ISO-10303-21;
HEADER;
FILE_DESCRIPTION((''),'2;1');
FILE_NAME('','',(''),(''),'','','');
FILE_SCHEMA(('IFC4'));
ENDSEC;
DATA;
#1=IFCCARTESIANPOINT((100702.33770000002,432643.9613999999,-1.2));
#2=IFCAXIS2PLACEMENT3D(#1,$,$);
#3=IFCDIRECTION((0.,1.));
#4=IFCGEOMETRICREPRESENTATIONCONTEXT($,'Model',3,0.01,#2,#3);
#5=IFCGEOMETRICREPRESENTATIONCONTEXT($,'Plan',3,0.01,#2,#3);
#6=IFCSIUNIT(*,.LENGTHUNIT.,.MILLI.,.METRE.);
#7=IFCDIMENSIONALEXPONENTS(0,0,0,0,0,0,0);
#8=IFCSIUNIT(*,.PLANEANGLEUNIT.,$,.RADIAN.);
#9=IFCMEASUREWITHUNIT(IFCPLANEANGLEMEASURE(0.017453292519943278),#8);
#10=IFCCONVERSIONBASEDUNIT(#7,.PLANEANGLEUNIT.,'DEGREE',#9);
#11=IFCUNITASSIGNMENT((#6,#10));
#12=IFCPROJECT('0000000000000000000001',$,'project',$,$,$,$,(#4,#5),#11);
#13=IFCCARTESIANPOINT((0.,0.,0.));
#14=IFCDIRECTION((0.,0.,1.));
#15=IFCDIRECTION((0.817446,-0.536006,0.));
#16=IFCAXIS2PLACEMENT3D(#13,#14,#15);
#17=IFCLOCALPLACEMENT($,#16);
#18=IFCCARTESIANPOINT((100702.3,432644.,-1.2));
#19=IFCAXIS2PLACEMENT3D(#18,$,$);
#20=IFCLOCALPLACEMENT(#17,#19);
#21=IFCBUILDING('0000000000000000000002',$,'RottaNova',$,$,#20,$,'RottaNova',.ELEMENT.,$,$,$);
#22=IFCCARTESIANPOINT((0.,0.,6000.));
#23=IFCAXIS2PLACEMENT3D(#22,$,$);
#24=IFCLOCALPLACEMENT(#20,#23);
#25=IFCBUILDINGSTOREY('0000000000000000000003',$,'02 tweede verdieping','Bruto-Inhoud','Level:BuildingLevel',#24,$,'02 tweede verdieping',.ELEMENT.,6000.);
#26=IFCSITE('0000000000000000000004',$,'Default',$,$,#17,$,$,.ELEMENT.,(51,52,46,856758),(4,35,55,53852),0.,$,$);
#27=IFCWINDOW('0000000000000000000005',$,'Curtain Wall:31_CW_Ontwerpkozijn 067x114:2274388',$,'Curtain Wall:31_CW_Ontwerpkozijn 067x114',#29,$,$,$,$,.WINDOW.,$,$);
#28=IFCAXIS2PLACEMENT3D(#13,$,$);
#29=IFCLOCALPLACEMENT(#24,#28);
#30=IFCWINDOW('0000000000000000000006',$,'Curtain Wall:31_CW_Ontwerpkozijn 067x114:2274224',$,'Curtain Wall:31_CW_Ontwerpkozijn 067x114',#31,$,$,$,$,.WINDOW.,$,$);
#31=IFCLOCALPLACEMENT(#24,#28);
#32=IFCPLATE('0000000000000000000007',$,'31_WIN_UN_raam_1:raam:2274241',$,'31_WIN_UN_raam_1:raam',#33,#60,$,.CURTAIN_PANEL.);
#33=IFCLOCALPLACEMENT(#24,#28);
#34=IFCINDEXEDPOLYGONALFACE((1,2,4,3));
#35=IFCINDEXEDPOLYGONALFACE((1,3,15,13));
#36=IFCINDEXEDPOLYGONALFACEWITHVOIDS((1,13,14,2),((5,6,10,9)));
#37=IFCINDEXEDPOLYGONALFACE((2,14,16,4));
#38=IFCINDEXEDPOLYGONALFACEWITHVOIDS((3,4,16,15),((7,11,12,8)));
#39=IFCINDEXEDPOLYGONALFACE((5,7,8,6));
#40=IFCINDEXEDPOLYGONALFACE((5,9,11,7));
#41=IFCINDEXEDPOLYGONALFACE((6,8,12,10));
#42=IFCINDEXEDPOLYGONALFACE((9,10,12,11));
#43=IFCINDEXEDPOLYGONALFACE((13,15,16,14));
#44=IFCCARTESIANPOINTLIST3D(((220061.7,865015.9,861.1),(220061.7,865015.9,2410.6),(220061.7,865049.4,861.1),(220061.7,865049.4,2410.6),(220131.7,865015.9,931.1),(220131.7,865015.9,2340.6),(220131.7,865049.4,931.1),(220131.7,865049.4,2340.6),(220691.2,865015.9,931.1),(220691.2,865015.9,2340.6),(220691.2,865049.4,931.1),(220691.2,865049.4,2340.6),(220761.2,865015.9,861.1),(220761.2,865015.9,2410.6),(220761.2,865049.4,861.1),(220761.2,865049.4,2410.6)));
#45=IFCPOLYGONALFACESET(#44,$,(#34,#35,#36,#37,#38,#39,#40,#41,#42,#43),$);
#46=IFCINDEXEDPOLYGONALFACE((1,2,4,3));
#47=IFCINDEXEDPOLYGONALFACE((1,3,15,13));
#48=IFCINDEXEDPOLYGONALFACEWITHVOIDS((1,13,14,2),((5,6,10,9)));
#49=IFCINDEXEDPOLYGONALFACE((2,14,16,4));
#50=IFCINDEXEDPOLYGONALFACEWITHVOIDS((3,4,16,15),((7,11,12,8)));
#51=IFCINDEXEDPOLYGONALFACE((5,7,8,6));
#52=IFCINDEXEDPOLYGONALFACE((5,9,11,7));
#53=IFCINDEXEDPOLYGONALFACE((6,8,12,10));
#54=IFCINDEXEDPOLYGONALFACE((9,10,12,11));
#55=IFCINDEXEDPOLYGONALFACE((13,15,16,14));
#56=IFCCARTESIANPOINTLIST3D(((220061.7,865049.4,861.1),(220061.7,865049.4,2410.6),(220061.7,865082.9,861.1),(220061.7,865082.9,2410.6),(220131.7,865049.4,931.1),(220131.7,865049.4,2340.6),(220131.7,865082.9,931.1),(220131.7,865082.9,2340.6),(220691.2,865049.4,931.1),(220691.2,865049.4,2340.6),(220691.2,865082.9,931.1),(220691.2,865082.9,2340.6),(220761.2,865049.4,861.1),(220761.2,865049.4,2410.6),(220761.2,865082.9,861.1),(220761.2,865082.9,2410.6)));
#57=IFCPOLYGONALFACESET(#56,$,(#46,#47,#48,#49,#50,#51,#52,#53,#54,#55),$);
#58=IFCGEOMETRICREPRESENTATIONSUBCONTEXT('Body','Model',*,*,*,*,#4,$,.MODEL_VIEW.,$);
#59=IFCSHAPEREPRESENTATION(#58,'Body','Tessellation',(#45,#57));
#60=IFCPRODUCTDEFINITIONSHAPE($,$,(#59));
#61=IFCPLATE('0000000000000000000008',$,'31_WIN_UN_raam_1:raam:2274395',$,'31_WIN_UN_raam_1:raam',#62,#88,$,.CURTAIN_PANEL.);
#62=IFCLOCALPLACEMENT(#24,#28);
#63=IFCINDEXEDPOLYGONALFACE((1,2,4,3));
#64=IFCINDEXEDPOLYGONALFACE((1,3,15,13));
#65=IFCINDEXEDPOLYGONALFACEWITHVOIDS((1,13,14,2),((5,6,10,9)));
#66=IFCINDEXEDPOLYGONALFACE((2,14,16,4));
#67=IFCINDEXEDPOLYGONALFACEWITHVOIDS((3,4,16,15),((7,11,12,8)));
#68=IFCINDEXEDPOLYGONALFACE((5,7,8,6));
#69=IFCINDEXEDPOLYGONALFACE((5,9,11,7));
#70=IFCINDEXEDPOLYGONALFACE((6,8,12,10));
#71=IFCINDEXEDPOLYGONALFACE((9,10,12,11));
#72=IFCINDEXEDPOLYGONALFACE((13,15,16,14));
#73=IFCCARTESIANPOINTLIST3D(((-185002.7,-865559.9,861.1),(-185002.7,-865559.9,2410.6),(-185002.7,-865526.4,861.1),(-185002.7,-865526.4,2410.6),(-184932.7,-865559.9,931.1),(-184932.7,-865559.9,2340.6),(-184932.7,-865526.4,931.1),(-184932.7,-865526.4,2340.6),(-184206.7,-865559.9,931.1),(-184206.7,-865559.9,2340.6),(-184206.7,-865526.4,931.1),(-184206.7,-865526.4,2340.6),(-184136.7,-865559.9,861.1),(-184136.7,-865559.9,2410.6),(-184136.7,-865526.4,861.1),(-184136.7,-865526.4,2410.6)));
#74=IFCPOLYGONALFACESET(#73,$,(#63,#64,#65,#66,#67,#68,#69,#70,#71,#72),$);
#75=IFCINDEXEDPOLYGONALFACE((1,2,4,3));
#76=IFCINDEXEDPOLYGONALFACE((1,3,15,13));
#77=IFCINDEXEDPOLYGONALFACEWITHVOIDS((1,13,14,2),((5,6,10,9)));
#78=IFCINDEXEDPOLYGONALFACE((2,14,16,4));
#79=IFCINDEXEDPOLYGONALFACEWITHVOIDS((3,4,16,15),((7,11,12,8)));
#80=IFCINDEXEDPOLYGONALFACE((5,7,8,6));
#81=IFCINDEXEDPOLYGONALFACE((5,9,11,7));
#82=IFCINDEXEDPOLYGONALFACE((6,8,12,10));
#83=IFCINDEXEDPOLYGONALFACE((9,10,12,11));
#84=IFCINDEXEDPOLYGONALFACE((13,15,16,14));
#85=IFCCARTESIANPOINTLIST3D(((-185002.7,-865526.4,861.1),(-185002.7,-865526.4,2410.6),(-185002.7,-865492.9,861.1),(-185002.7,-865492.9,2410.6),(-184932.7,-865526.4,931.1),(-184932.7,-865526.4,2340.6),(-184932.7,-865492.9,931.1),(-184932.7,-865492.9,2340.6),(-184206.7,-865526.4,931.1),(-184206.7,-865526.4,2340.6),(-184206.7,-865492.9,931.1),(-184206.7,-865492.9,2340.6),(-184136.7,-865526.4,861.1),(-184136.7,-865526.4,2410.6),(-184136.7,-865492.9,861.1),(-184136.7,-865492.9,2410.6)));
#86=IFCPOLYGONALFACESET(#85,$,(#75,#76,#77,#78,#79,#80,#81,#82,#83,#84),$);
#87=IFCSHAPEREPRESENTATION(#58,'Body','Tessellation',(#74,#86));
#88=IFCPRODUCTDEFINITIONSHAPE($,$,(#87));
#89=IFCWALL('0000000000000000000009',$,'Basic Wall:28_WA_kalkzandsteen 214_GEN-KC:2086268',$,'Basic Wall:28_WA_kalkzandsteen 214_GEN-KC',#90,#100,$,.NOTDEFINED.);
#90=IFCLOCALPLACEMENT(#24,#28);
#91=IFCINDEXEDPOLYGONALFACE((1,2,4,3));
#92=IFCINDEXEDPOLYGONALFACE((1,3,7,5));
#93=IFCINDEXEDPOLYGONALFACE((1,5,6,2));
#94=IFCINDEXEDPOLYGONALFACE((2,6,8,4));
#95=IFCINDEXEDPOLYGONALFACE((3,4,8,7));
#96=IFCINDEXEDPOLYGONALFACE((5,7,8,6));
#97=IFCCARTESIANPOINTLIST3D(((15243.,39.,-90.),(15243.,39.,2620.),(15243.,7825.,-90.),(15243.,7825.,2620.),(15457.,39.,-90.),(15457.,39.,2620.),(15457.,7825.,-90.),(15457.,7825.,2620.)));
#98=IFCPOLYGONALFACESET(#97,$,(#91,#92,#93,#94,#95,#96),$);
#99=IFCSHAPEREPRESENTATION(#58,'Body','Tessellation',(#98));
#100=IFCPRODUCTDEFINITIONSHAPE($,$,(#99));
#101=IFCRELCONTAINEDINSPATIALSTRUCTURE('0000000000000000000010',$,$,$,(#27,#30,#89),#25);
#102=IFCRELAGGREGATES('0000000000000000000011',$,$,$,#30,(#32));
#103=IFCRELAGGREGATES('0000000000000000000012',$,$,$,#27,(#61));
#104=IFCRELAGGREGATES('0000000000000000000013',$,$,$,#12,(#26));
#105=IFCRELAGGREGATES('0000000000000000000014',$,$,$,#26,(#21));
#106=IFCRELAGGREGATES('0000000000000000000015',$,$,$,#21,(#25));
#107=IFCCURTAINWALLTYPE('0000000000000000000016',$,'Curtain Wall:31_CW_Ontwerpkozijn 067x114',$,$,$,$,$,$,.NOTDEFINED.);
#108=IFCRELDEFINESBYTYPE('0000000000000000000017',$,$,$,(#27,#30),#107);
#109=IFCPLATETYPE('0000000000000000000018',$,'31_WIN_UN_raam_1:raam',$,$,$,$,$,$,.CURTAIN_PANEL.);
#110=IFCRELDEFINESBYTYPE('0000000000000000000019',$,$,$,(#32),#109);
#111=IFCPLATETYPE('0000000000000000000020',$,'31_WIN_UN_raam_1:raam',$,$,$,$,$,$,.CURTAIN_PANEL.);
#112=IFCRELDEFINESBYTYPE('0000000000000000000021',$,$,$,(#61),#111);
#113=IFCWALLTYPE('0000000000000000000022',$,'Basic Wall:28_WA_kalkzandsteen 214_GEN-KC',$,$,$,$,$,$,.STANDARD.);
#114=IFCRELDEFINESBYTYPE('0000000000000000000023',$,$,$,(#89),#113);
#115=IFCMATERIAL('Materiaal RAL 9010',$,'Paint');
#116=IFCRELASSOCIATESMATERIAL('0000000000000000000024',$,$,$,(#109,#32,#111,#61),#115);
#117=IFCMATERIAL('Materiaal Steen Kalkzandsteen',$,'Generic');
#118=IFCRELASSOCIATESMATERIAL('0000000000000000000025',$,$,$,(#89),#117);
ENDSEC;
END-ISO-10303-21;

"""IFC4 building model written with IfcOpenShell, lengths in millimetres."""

from ifc_helpers import new_model, entity, si_unit, converted_unit, direction, frame, place, context, subcontext, project, spatial, indexed_curve, outline, extrude, source, transform, mapped, material, type_object, type_shapes, element, aggregate, save


model = new_model("IFC4")

# Units and contexts
model_context = context("Model", 3, precision=0.01, world=frame((100702.33770000002, 432643.9613999999, -1.2)), true_north=direction((0.0, 1.0)))
plan_context = context("Plan", 3, precision=0.01, world=frame((100702.33770000002, 432643.9613999999, -1.2)), true_north=direction((0.0, 1.0)))
body_context = subcontext(model_context, "Body", "Model", "MODEL_VIEW")
ifc_project = project(units=[si_unit("LENGTHUNIT", "METRE", prefix="MILLI"), converted_unit("PLANEANGLEUNIT", "DEGREE", entity("IfcPlaneAngleMeasure", 0.017453292519943278), si_unit("PLANEANGLEUNIT", "RADIAN"), dimensions=[0, 0, 0, 0, 0, 0, 0])], contexts=[model_context, plan_context])

# Site, building, storey
site_placement = place(None, frame((0.0, 0.0, 0.0), z_axis=(0.0, 0.0, 1.0), x_axis=(0.817446, -0.536006, 0.0)))
site = spatial("IfcSite", under=ifc_project, at=site_placement, Name="Default", CompositionType="ELEMENT", RefLatitude=(51, 52, 46, 856758), RefLongitude=(4, 35, 55, 53852), RefElevation=0.0)
building_placement = place(site_placement, frame((100702.3, 432644.0, -1.2)))
building = spatial("IfcBuilding", under=site, at=building_placement, Name="RottaNova", LongName="RottaNova", CompositionType="ELEMENT")
storey_placement = place(building_placement, frame((0.0, 0.0, 6000.0)))
storey = spatial("IfcBuildingStorey", under=building, at=storey_placement, Name="02 tweede verdieping", Description="Bruto-Inhoud", ObjectType="Level:BuildingLevel", LongName="02 tweede verdieping", CompositionType="ELEMENT", Elevation=6000.0)

# Window
curtain_wall_type = type_object("IfcCurtainWallType", Name="Curtain Wall:31_CW_Ontwerpkozijn 067x114", PredefinedType="NOTDEFINED")
window_1_placement = place(storey_placement, frame((0.0, 0.0, -6000.0)))
window_1 = element("IfcWindow", 1, at=window_1_placement, inside=storey, type_object=curtain_wall_type, Name="Curtain Wall:31_CW_Ontwerpkozijn 067x114:2274388", ObjectType="Curtain Wall:31_CW_Ontwerpkozijn 067x114", PredefinedType="WINDOW")

# Window
window_2_placement = place(storey_placement, frame((0.0, 0.0, -6000.0)))
window_2 = element("IfcWindow", 2, at=window_2_placement, inside=storey, type_object=curtain_wall_type, Name="Curtain Wall:31_CW_Ontwerpkozijn 067x114:2274224", ObjectType="Curtain Wall:31_CW_Ontwerpkozijn 067x114", PredefinedType="WINDOW")

# Plates
ifc_material_1 = material(Name="Materiaal RAL 9010", Category="Paint")
plate_type_1 = type_object("IfcPlateType", Name="31_WIN_UN_raam_1:raam", PredefinedType="CURTAIN_PANEL", material=ifc_material_1)
shared_shape_1 = source(frame((100702.3, 432644.0, -1.2)), body_context, "Body", "SweptSolid", [
    extrude(outline(indexed_curve([(-349.7, -774.8), (349.7, -774.8), (349.7, 774.8), (-349.7, 774.8), (-349.7, -774.8)], self_intersect=False), holes=[indexed_curve([(-279.7, 704.8), (279.7, 704.8), (279.7, -704.8), (-279.7, -704.8), (-279.7, 704.8)], self_intersect=False)]), frame((0.0, -92.0, 774.8), z_axis=(0.0, 1.0, 0.0), x_axis=(1.0, 0.0, 0.0)), (0.0, 0.0, 1.0), 33.5),
    extrude(outline(indexed_curve([(-349.7, -774.8), (349.7, -774.8), (349.7, 774.8), (-349.7, 774.8), (-349.7, -774.8)], self_intersect=False), holes=[indexed_curve([(-279.7, 704.7), (279.7, 704.7), (279.7, -704.8), (-279.7, -704.8), (-279.7, 704.7)], self_intersect=False)]), frame((0.0, -58.5, 774.8), z_axis=(0.0, 1.0, 0.0), x_axis=(1.0, 0.0, 0.0)), (0.0, 0.0, 1.0), 33.5),
])
type_shapes(plate_type_1, [shared_shape_1])
plate_1_placement = place(window_2_placement, frame((19006.8, -180.0, 6863.5)))
plate_1 = element("IfcPlate", 3, at=plate_1_placement, type_object=plate_type_1, material=ifc_material_1, Name="31_WIN_UN_raam_1:raam:2274241", ObjectType="31_WIN_UN_raam_1:raam", PredefinedType="CURTAIN_PANEL", context=body_context, shape_type="MappedRepresentation", body=[
    mapped(shared_shape_1, transform((100702.3, 432644.0, -1.2), scale=1.0)),
])
aggregate(window_2, [plate_1])
plate_type_2 = type_object("IfcPlateType", Name="31_WIN_UN_raam_1:raam", PredefinedType="CURTAIN_PANEL", material=ifc_material_1)
shared_shape_2 = source(frame((100702.3, 432644.0, -1.2)), body_context, "Body", "SweptSolid", [
    extrude(outline(indexed_curve([(-433.0, -774.7), (433.0, -774.7), (433.0, 774.7), (-433.0, 774.7), (-433.0, -774.7)], self_intersect=False), holes=[indexed_curve([(-363.0, 704.7), (363.0, 704.7), (363.0, -704.8), (-363.0, -704.8), (-363.0, 704.7)], self_intersect=False)]), frame((0.0, 58.5, 774.8), z_axis=(0.0, 1.0, 0.0), x_axis=(1.0, 0.0, 0.0)), (0.0, 0.0, 1.0), 33.5),
    extrude(outline(indexed_curve([(-433.0, -774.7), (433.0, -774.7), (433.0, 774.7), (-433.0, 774.7), (-433.0, -774.7)], self_intersect=False), holes=[indexed_curve([(-363.0, 704.7), (363.0, 704.7), (363.0, -704.8), (-363.0, -704.8), (-363.0, 704.7)], self_intersect=False)]), frame((0.0, 25.0, 774.8), z_axis=(0.0, 1.0, 0.0), x_axis=(1.0, 0.0, 0.0)), (0.0, 0.0, 1.0), 33.5),
])
type_shapes(plate_type_2, [shared_shape_2])
plate_2_placement = place(window_1_placement, frame((16835.0, -180.0, 6863.5), z_axis=(0.0, 0.0, 1.0), x_axis=(-1.0, 0.0, 0.0)))
plate_2 = element("IfcPlate", 4, at=plate_2_placement, type_object=plate_type_2, material=ifc_material_1, Name="31_WIN_UN_raam_1:raam:2274395", ObjectType="31_WIN_UN_raam_1:raam", PredefinedType="CURTAIN_PANEL", context=body_context, shape_type="MappedRepresentation", body=[
    mapped(shared_shape_2, transform((100702.3, 432644.0, -1.2), scale=1.0)),
])
aggregate(window_1, [plate_2])

# Wall
ifc_material_2 = material(Name="Materiaal Steen Kalkzandsteen", Category="Generic")
wall_type = type_object("IfcWallType", Name="Basic Wall:28_WA_kalkzandsteen 214_GEN-KC", PredefinedType="STANDARD")
wall_1_placement = place(storey_placement, frame((15350.0, 39.0, -90.0), z_axis=(0.0, 0.0, 1.0), x_axis=(0.0, 1.0, 0.0)))
element("IfcWall", 5, at=wall_1_placement, inside=storey, type_object=wall_type, material=ifc_material_2, Name="Basic Wall:28_WA_kalkzandsteen 214_GEN-KC:2086268", ObjectType="Basic Wall:28_WA_kalkzandsteen 214_GEN-KC", PredefinedType="NOTDEFINED", context=body_context, shape_type="SweptSolid", body=[
    extrude(outline(indexed_curve([(-3893.0, -107.0), (3893.0, -107.0), (3893.0, 107.0), (-3893.0, 107.0), (-3893.0, -107.0)], self_intersect=False)), frame((3893.0, 0.0, 0.0)), (0.0, 0.0, 1.0), 2710.0),
])

save(model, "model.ifc")
